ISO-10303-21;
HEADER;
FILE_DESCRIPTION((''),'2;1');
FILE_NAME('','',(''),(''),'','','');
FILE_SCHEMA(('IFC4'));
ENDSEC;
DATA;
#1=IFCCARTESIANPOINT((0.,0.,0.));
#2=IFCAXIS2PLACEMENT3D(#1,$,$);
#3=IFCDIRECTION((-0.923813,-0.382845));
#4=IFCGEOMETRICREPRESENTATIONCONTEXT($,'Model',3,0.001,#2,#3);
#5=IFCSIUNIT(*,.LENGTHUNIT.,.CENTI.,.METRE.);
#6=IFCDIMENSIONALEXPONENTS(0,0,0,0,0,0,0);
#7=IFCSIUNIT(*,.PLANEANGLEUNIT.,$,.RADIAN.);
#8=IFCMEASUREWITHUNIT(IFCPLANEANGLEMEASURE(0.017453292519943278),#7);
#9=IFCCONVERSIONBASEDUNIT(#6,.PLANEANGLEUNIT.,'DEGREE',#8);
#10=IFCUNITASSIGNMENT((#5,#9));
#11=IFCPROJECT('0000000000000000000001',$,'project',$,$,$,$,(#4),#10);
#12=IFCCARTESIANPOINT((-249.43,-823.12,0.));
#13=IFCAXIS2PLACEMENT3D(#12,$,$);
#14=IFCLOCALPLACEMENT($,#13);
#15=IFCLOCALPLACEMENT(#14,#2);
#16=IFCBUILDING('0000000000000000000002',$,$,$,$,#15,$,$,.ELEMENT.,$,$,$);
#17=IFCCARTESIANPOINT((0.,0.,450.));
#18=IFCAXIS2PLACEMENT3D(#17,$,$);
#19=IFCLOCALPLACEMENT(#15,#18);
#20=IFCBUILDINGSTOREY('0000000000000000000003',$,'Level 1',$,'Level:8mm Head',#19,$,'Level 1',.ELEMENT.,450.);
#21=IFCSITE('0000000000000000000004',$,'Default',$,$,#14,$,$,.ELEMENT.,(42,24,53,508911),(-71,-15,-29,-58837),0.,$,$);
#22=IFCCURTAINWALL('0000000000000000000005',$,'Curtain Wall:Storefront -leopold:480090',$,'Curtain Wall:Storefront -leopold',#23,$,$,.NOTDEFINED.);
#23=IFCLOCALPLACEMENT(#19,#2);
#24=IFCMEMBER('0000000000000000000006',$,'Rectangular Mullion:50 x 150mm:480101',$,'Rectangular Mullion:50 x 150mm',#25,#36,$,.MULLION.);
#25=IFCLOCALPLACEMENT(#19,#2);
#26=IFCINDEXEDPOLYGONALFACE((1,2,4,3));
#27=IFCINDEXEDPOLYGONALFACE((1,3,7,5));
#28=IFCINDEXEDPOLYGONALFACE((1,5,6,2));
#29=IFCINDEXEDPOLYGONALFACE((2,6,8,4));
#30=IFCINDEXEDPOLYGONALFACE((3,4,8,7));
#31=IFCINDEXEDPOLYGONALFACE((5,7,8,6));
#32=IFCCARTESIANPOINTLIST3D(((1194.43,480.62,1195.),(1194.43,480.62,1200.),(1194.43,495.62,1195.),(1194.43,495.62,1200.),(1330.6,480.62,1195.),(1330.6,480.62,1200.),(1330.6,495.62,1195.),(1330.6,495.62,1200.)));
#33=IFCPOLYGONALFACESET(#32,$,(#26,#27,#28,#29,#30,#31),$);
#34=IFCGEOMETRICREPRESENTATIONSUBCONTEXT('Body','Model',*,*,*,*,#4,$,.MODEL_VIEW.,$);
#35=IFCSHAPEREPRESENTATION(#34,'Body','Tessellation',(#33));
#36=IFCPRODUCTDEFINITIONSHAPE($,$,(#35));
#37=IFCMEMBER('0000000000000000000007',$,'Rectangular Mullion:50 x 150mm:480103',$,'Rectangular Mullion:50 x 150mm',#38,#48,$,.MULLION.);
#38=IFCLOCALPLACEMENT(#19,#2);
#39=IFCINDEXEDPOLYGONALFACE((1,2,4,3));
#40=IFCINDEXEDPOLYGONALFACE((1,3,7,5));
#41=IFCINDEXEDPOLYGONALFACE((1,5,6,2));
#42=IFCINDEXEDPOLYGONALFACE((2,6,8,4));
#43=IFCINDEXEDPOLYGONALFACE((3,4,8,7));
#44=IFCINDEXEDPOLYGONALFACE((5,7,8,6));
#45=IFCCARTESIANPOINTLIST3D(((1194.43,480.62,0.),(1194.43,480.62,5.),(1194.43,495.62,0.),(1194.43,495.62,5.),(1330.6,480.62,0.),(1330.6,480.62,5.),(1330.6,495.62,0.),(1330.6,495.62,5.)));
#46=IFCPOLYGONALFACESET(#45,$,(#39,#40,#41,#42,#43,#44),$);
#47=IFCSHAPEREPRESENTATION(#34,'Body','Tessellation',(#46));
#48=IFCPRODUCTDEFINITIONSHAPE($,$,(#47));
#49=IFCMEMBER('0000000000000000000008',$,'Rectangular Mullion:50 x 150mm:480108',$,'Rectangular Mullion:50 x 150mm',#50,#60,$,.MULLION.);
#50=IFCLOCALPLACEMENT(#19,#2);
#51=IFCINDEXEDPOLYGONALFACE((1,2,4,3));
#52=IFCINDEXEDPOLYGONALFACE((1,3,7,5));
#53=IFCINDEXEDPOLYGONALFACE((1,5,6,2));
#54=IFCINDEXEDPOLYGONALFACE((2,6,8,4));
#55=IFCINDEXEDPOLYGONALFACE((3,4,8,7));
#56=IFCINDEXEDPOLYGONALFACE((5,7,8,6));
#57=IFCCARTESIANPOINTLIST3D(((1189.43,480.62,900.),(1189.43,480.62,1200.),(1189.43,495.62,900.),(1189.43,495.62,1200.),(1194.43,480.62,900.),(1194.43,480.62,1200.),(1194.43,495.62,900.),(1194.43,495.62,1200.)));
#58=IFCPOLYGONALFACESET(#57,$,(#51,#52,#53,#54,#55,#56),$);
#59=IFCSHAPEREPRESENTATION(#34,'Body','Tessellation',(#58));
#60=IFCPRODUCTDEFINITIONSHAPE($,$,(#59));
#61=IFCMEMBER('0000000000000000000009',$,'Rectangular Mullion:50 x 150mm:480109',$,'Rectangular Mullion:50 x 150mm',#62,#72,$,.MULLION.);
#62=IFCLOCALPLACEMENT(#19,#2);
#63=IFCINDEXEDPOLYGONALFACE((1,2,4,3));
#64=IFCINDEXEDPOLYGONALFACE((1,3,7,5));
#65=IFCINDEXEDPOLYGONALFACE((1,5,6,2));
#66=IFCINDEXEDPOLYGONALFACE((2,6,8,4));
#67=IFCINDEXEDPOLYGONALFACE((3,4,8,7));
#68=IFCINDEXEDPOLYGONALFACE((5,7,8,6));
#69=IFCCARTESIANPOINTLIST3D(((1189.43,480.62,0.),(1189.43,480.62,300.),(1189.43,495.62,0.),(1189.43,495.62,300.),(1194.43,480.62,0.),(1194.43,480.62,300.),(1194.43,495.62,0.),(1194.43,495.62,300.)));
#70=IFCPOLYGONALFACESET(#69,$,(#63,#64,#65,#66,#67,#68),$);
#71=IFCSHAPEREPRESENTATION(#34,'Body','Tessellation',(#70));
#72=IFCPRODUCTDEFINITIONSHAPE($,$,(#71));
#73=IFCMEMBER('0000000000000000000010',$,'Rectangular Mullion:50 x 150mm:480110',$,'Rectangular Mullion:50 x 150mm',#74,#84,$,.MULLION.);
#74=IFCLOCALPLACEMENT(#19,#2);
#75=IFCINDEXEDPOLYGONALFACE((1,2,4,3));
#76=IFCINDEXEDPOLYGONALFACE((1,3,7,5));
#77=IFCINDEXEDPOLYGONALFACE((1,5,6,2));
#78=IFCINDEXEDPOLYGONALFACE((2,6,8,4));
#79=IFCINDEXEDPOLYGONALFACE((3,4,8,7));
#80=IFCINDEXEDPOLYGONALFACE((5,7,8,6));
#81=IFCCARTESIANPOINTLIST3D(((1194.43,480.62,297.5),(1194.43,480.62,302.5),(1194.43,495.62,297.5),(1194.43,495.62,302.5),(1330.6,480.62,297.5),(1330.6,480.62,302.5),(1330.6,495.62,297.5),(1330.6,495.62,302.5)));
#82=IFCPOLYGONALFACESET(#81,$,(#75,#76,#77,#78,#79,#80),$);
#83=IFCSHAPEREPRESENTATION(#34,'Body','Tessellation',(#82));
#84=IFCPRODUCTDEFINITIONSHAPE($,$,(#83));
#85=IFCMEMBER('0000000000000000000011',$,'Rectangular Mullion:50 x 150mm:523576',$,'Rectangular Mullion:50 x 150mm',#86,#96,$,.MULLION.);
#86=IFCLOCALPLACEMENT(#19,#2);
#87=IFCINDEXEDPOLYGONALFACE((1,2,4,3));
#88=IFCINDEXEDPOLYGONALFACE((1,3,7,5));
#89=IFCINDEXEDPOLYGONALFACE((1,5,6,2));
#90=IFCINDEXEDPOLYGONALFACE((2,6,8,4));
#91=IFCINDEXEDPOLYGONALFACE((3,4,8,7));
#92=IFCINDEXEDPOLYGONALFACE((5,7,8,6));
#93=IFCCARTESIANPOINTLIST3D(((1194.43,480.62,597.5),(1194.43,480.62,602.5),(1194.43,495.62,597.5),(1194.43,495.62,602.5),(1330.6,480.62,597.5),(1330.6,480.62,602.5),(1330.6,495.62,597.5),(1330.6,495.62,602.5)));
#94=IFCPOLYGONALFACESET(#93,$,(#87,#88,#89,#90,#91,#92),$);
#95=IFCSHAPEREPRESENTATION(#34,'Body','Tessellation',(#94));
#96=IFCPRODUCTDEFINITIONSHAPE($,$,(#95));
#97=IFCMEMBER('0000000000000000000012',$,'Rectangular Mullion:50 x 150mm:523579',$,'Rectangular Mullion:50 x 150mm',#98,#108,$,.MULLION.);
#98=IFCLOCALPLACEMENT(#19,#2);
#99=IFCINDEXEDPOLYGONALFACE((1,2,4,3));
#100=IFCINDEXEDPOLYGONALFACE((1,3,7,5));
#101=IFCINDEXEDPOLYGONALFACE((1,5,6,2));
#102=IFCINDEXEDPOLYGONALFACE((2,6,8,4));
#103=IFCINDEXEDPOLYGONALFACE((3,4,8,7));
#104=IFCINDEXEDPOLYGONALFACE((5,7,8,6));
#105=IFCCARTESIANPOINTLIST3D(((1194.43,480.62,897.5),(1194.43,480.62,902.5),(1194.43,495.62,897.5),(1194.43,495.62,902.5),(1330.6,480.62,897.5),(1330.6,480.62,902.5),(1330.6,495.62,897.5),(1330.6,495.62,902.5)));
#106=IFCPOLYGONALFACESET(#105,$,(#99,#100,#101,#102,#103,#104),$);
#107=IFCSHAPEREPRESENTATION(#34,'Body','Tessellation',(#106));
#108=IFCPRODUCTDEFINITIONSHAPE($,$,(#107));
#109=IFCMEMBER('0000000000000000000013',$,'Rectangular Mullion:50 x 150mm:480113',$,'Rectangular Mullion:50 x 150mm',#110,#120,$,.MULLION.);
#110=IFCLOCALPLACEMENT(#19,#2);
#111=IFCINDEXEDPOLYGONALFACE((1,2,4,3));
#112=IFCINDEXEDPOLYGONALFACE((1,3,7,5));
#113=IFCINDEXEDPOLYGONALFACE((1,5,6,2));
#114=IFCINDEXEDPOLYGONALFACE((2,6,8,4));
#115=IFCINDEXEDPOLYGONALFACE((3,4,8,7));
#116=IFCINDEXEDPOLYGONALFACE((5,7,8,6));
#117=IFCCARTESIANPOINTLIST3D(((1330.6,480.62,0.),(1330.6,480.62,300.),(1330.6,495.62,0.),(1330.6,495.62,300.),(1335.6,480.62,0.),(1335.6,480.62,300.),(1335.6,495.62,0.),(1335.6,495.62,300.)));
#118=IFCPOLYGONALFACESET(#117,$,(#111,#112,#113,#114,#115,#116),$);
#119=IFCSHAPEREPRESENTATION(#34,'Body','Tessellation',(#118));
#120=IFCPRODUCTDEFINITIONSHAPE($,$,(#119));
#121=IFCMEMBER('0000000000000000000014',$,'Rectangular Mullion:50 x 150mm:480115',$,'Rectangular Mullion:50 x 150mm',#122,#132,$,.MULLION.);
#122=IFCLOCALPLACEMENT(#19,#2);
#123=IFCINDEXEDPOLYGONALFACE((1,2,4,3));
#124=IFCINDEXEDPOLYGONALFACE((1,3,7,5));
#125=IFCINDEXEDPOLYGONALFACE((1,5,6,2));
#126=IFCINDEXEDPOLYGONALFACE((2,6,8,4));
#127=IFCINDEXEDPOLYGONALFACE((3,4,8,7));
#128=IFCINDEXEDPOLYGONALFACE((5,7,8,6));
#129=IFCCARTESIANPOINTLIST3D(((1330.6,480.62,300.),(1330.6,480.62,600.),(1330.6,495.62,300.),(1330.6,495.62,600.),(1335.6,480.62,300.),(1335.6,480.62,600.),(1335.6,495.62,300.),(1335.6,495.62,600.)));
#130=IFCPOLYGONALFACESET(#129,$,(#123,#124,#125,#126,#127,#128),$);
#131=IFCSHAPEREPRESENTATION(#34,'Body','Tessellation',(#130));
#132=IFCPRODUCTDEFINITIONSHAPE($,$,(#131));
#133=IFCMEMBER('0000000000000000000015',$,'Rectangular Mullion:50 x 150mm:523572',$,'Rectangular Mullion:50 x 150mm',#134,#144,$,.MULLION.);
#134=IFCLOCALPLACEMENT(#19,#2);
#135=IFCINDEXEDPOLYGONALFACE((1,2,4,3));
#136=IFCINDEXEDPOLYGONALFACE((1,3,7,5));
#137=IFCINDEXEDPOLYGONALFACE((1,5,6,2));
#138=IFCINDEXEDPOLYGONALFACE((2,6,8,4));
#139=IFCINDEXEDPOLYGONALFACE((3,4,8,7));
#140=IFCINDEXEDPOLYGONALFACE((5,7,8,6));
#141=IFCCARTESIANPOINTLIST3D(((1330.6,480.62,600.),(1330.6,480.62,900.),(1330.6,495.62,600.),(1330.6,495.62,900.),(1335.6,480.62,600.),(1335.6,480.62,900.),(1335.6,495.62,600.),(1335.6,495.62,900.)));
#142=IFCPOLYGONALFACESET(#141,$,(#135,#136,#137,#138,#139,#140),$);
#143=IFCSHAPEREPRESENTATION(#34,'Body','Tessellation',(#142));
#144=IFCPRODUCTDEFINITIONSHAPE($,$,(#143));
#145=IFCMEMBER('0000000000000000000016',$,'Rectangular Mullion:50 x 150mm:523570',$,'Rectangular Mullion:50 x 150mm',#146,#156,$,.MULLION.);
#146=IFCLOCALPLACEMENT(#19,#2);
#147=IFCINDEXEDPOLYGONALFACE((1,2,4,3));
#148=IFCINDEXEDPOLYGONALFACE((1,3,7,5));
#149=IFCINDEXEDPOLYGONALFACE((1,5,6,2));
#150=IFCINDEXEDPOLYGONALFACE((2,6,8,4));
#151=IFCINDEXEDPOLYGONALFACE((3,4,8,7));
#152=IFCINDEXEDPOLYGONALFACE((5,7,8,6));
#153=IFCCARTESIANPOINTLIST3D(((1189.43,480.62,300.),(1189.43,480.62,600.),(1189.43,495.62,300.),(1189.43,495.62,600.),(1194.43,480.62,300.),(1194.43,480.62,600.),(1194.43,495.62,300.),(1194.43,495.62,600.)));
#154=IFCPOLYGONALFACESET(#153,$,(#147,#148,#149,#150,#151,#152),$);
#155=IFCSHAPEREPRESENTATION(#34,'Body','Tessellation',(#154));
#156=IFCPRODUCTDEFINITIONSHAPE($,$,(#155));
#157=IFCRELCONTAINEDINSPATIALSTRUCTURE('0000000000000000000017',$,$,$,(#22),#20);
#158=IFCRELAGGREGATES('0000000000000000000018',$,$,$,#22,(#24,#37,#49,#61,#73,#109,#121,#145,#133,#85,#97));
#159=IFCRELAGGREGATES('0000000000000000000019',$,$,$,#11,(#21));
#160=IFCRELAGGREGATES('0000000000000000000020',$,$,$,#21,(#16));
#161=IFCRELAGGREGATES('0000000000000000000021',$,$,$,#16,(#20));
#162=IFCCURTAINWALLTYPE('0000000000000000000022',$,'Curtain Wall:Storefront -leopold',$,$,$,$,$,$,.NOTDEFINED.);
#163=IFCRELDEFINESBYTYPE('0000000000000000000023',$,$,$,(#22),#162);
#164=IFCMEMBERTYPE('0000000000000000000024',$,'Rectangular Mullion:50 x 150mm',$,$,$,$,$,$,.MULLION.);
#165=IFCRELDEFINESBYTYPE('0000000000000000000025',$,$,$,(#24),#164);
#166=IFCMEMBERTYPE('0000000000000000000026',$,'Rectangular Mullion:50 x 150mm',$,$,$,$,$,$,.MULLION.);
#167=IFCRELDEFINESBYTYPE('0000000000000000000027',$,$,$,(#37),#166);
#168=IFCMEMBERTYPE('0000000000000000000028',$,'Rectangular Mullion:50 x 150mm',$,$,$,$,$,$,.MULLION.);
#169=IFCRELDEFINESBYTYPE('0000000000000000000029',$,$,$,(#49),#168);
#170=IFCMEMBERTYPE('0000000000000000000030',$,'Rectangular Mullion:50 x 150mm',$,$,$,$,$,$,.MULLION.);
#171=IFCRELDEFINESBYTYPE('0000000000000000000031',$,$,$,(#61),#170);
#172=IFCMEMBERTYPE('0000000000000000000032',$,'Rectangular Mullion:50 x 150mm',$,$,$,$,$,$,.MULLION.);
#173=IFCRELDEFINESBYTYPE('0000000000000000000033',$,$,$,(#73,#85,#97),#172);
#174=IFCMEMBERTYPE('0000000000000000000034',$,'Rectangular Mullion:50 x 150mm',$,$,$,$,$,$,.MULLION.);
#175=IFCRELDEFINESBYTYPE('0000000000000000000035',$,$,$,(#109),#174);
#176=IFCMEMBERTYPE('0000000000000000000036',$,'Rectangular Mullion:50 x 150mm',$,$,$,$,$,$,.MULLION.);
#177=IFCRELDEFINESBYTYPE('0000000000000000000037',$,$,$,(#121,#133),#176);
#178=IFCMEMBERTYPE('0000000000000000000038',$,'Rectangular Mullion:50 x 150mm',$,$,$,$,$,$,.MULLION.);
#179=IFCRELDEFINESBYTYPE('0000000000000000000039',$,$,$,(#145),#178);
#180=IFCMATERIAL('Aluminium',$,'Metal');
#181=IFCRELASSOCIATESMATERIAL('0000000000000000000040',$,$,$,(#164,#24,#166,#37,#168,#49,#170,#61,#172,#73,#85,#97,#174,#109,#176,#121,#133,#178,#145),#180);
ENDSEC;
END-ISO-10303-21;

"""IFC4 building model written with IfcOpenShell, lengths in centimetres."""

from ifc_helpers import new_model, entity, si_unit, converted_unit, direction, frame, origin, place, context, subcontext, project, spatial, indexed_curve, outline, extrude, source, transform, mapped, material, type_object, type_shapes, element, aggregate, save


model = new_model("IFC4")

# Units and contexts
model_context = context("Model", 3, precision=0.001, world=origin(), true_north=direction((-0.923813, -0.382845)))
body_context = subcontext(model_context, "Body", "Model", "MODEL_VIEW")
ifc_project = project(units=[si_unit("LENGTHUNIT", "METRE", prefix="CENTI"), converted_unit("PLANEANGLEUNIT", "DEGREE", entity("IfcPlaneAngleMeasure", 0.017453292519943278), si_unit("PLANEANGLEUNIT", "RADIAN"), dimensions=[0, 0, 0, 0, 0, 0, 0])], contexts=[model_context])

# Site, building, storey
site_placement = place(None, frame((-249.43, -823.12, 0.0)))
site = spatial("IfcSite", under=ifc_project, at=site_placement, Name="Default", CompositionType="ELEMENT", RefLatitude=(42, 24, 53, 508911), RefLongitude=(-71, -15, -29, -58837), RefElevation=0.0)
building_placement = place(site_placement, origin())
building = spatial("IfcBuilding", under=site, at=building_placement, CompositionType="ELEMENT")
storey_placement = place(building_placement, frame((0.0, 0.0, 450.0)))
storey = spatial("IfcBuildingStorey", under=building, at=storey_placement, Name="Level 1", ObjectType="Level:8mm Head", LongName="Level 1", CompositionType="ELEMENT", Elevation=450.0)

# Curtain wall, members
curtain_wall_type = type_object("IfcCurtainWallType", Name="Curtain Wall:Storefront -leopold", PredefinedType="NOTDEFINED")
curtain_wall_placement = place(storey_placement, frame((0.0, 0.0, -450.0)))
curtain_wall = element("IfcCurtainWall", 1, at=curtain_wall_placement, inside=storey, type_object=curtain_wall_type, Name="Curtain Wall:Storefront -leopold:480090", ObjectType="Curtain Wall:Storefront -leopold", PredefinedType="NOTDEFINED")
ifc_material_1 = material(Name="Aluminium", Category="Metal")
member_type_1 = type_object("IfcMemberType", Name="Rectangular Mullion:50 x 150mm", PredefinedType="MULLION", material=ifc_material_1)
shared_shape_1 = source(origin(), body_context, "Body", "SweptSolid", [
    extrude(outline(indexed_curve([(-2.5, -7.5), (2.5, -7.5), (2.5, 7.5), (-2.5, 7.5), (-2.5, -7.5)], self_intersect=False)), frame((-2.5, 0.0, -136.17), z_axis=(0.0, 0.0, 1.0), x_axis=(-1.0, 0.0, 0.0)), (0.0, 0.0, 1.0), 136.17),
])
type_shapes(member_type_1, [shared_shape_1])
member_1_placement = place(curtain_wall_placement, frame((1330.6, 488.12, 1650.0), z_axis=(1.0, 0.0, 0.0), x_axis=(0.0, 0.0, 1.0)))
member_1 = element("IfcMember", 2, at=member_1_placement, type_object=member_type_1, material=ifc_material_1, Name="Rectangular Mullion:50 x 150mm:480101", ObjectType="Rectangular Mullion:50 x 150mm", PredefinedType="MULLION", context=body_context, shape_type="MappedRepresentation", body=[
    mapped(shared_shape_1, transform((0.0, 0.0, 0.0), scale=1.0)),
])
member_type_2 = type_object("IfcMemberType", Name="Rectangular Mullion:50 x 150mm", PredefinedType="MULLION", material=ifc_material_1)
shared_shape_2 = source(origin(), body_context, "Body", "SweptSolid", [
    extrude(outline(indexed_curve([(-2.5, -7.5), (2.5, -7.5), (2.5, 7.5), (-2.5, 7.5), (-2.5, -7.5)], self_intersect=False)), frame((-2.5, 0.0, -136.17), z_axis=(0.0, 0.0, 1.0), x_axis=(-1.0, 0.0, 0.0)), (0.0, 0.0, 1.0), 136.17),
])
type_shapes(member_type_2, [shared_shape_2])
member_2_placement = place(curtain_wall_placement, frame((1194.43, 488.12, 450.0), z_axis=(-1.0, 0.0, 0.0), x_axis=(0.0, 0.0, -1.0)))
member_2 = element("IfcMember", 3, at=member_2_placement, type_object=member_type_2, material=ifc_material_1, Name="Rectangular Mullion:50 x 150mm:480103", ObjectType="Rectangular Mullion:50 x 150mm", PredefinedType="MULLION", context=body_context, shape_type="MappedRepresentation", body=[
    mapped(shared_shape_2, transform((0.0, 0.0, 0.0), scale=1.0)),
])
member_type_3 = type_object("IfcMemberType", Name="Rectangular Mullion:50 x 150mm", PredefinedType="MULLION", material=ifc_material_1)
shared_shape_3 = source(origin(), body_context, "Body", "SweptSolid", [
    extrude(outline(indexed_curve([(-2.5, -7.5), (2.5, -7.5), (2.5, 7.5), (-2.5, 7.5), (-2.5, -7.5)], self_intersect=False)), frame((-2.5, 0.0, -300.0), z_axis=(0.0, 0.0, 1.0), x_axis=(-1.0, 0.0, 0.0)), (0.0, 0.0, 1.0), 300.0),
])
type_shapes(member_type_3, [shared_shape_3])
member_3_placement = place(curtain_wall_placement, frame((1189.43, 488.12, 1650.0), z_axis=(0.0, 0.0, 1.0), x_axis=(-1.0, 0.0, 0.0)))
member_3 = element("IfcMember", 4, at=member_3_placement, type_object=member_type_3, material=ifc_material_1, Name="Rectangular Mullion:50 x 150mm:480108", ObjectType="Rectangular Mullion:50 x 150mm", PredefinedType="MULLION", context=body_context, shape_type="MappedRepresentation", body=[
    mapped(shared_shape_3, transform((0.0, 0.0, 0.0), scale=1.0)),
])
member_type_4 = type_object("IfcMemberType", Name="Rectangular Mullion:50 x 150mm", PredefinedType="MULLION", material=ifc_material_1)
shared_shape_4 = source(origin(), body_context, "Body", "SweptSolid", [
    extrude(outline(indexed_curve([(-2.5, -7.5), (2.5, -7.5), (2.5, 7.5), (-2.5, 7.5), (-2.5, -7.5)], self_intersect=False)), frame((-2.5, 0.0, -300.0), z_axis=(0.0, 0.0, 1.0), x_axis=(-1.0, 0.0, 0.0)), (0.0, 0.0, 1.0), 300.0),
])
type_shapes(member_type_4, [shared_shape_4])
member_4_placement = place(curtain_wall_placement, frame((1189.43, 488.12, 750.0), z_axis=(0.0, 0.0, 1.0), x_axis=(-1.0, 0.0, 0.0)))
member_4 = element("IfcMember", 5, at=member_4_placement, type_object=member_type_4, material=ifc_material_1, Name="Rectangular Mullion:50 x 150mm:480109", ObjectType="Rectangular Mullion:50 x 150mm", PredefinedType="MULLION", context=body_context, shape_type="MappedRepresentation", body=[
    mapped(shared_shape_4, transform((0.0, 0.0, 0.0), scale=1.0)),
])
member_type_5 = type_object("IfcMemberType", Name="Rectangular Mullion:50 x 150mm", PredefinedType="MULLION", material=ifc_material_1)
shared_shape_5 = source(origin(), body_context, "Body", "SweptSolid", [
    extrude(outline(indexed_curve([(-2.5, -7.5), (2.5, -7.5), (2.5, 7.5), (-2.5, 7.5), (-2.5, -7.5)], self_intersect=False)), frame((0.0, 0.0, -136.17), z_axis=(0.0, 0.0, 1.0), x_axis=(-1.0, 0.0, 0.0)), (0.0, 0.0, 1.0), 136.17),
])
type_shapes(member_type_5, [shared_shape_5])
member_5_placement = place(curtain_wall_placement, frame((1330.6, 488.12, 750.0), z_axis=(1.0, 0.0, 0.0), x_axis=(0.0, 0.0, 1.0)))
member_5 = element("IfcMember", 6, at=member_5_placement, type_object=member_type_5, material=ifc_material_1, Name="Rectangular Mullion:50 x 150mm:480110", ObjectType="Rectangular Mullion:50 x 150mm", PredefinedType="MULLION", context=body_context, shape_type="MappedRepresentation", body=[
    mapped(shared_shape_5, transform((0.0, 0.0, 0.0), scale=1.0)),
])
member_6_placement = place(curtain_wall_placement, frame((1330.6, 488.12, 1050.0), z_axis=(1.0, 0.0, 0.0), x_axis=(0.0, 0.0, 1.0)))
member_6 = element("IfcMember", 7, at=member_6_placement, type_object=member_type_5, material=ifc_material_1, Name="Rectangular Mullion:50 x 150mm:523576", ObjectType="Rectangular Mullion:50 x 150mm", PredefinedType="MULLION", context=body_context, shape_type="MappedRepresentation", body=[
    mapped(shared_shape_5, transform((0.0, 0.0, 0.0), scale=1.0)),
])
member_7_placement = place(curtain_wall_placement, frame((1330.6, 488.12, 1350.0), z_axis=(1.0, 0.0, 0.0), x_axis=(0.0, 0.0, 1.0)))
member_7 = element("IfcMember", 8, at=member_7_placement, type_object=member_type_5, material=ifc_material_1, Name="Rectangular Mullion:50 x 150mm:523579", ObjectType="Rectangular Mullion:50 x 150mm", PredefinedType="MULLION", context=body_context, shape_type="MappedRepresentation", body=[
    mapped(shared_shape_5, transform((0.0, 0.0, 0.0), scale=1.0)),
])
member_type_6 = type_object("IfcMemberType", Name="Rectangular Mullion:50 x 150mm", PredefinedType="MULLION", material=ifc_material_1)
shared_shape_6 = source(origin(), body_context, "Body", "SweptSolid", [
    extrude(outline(indexed_curve([(-2.5, -7.5), (2.5, -7.5), (2.5, 7.5), (-2.5, 7.5), (-2.5, -7.5)], self_intersect=False)), frame((0.0, 0.0, -300.0), z_axis=(0.0, 0.0, 1.0), x_axis=(-1.0, 0.0, 0.0)), (0.0, 0.0, 1.0), 300.0),
])
type_shapes(member_type_6, [shared_shape_6])
member_8_placement = place(curtain_wall_placement, frame((1333.1, 488.12, 450.0), z_axis=(0.0, 0.0, -1.0), x_axis=(1.0, 0.0, 0.0)))
member_8 = element("IfcMember", 9, at=member_8_placement, type_object=member_type_6, material=ifc_material_1, Name="Rectangular Mullion:50 x 150mm:480113", ObjectType="Rectangular Mullion:50 x 150mm", PredefinedType="MULLION", context=body_context, shape_type="MappedRepresentation", body=[
    mapped(shared_shape_6, transform((0.0, 0.0, 0.0), scale=1.0)),
])
member_type_7 = type_object("IfcMemberType", Name="Rectangular Mullion:50 x 150mm", PredefinedType="MULLION", material=ifc_material_1)
shared_shape_7 = source(origin(), body_context, "Body", "SweptSolid", [
    extrude(outline(indexed_curve([(-2.5, -7.5), (2.5, -7.5), (2.5, 7.5), (-2.5, 7.5), (-2.5, -7.5)], self_intersect=False)), frame((0.0, 0.0, -300.0), z_axis=(0.0, 0.0, 1.0), x_axis=(-1.0, 0.0, 0.0)), (0.0, 0.0, 1.0), 300.0),
])
type_shapes(member_type_7, [shared_shape_7])
member_9_placement = place(curtain_wall_placement, frame((1333.1, 488.12, 750.0), z_axis=(0.0, 0.0, -1.0), x_axis=(1.0, 0.0, 0.0)))
member_9 = element("IfcMember", 10, at=member_9_placement, type_object=member_type_7, material=ifc_material_1, Name="Rectangular Mullion:50 x 150mm:480115", ObjectType="Rectangular Mullion:50 x 150mm", PredefinedType="MULLION", context=body_context, shape_type="MappedRepresentation", body=[
    mapped(shared_shape_7, transform((0.0, 0.0, 0.0), scale=1.0)),
])
member_10_placement = place(curtain_wall_placement, frame((1333.1, 488.12, 1050.0), z_axis=(0.0, 0.0, -1.0), x_axis=(1.0, 0.0, 0.0)))
member_10 = element("IfcMember", 11, at=member_10_placement, type_object=member_type_7, material=ifc_material_1, Name="Rectangular Mullion:50 x 150mm:523572", ObjectType="Rectangular Mullion:50 x 150mm", PredefinedType="MULLION", context=body_context, shape_type="MappedRepresentation", body=[
    mapped(shared_shape_7, transform((0.0, 0.0, 0.0), scale=1.0)),
])
member_type_8 = type_object("IfcMemberType", Name="Rectangular Mullion:50 x 150mm", PredefinedType="MULLION", material=ifc_material_1)
shared_shape_8 = source(origin(), body_context, "Body", "SweptSolid", [
    extrude(outline(indexed_curve([(-2.5, -7.5), (2.5, -7.5), (2.5, 7.5), (-2.5, 7.5), (-2.5, -7.5)], self_intersect=False)), frame((-2.5, 0.0, -300.0), z_axis=(0.0, 0.0, 1.0), x_axis=(-1.0, 0.0, 0.0)), (0.0, 0.0, 1.0), 300.0),
])
type_shapes(member_type_8, [shared_shape_8])
member_11_placement = place(curtain_wall_placement, frame((1189.43, 488.12, 1050.0), z_axis=(0.0, 0.0, 1.0), x_axis=(-1.0, 0.0, 0.0)))
member_11 = element("IfcMember", 12, at=member_11_placement, type_object=member_type_8, material=ifc_material_1, Name="Rectangular Mullion:50 x 150mm:523570", ObjectType="Rectangular Mullion:50 x 150mm", PredefinedType="MULLION", context=body_context, shape_type="MappedRepresentation", body=[
    mapped(shared_shape_8, transform((0.0, 0.0, 0.0), scale=1.0)),
])
aggregate(curtain_wall, [member_1, member_2, member_3, member_4, member_5, member_8, member_9, member_11, member_10, member_6, member_7])

save(model, "model.ifc")
